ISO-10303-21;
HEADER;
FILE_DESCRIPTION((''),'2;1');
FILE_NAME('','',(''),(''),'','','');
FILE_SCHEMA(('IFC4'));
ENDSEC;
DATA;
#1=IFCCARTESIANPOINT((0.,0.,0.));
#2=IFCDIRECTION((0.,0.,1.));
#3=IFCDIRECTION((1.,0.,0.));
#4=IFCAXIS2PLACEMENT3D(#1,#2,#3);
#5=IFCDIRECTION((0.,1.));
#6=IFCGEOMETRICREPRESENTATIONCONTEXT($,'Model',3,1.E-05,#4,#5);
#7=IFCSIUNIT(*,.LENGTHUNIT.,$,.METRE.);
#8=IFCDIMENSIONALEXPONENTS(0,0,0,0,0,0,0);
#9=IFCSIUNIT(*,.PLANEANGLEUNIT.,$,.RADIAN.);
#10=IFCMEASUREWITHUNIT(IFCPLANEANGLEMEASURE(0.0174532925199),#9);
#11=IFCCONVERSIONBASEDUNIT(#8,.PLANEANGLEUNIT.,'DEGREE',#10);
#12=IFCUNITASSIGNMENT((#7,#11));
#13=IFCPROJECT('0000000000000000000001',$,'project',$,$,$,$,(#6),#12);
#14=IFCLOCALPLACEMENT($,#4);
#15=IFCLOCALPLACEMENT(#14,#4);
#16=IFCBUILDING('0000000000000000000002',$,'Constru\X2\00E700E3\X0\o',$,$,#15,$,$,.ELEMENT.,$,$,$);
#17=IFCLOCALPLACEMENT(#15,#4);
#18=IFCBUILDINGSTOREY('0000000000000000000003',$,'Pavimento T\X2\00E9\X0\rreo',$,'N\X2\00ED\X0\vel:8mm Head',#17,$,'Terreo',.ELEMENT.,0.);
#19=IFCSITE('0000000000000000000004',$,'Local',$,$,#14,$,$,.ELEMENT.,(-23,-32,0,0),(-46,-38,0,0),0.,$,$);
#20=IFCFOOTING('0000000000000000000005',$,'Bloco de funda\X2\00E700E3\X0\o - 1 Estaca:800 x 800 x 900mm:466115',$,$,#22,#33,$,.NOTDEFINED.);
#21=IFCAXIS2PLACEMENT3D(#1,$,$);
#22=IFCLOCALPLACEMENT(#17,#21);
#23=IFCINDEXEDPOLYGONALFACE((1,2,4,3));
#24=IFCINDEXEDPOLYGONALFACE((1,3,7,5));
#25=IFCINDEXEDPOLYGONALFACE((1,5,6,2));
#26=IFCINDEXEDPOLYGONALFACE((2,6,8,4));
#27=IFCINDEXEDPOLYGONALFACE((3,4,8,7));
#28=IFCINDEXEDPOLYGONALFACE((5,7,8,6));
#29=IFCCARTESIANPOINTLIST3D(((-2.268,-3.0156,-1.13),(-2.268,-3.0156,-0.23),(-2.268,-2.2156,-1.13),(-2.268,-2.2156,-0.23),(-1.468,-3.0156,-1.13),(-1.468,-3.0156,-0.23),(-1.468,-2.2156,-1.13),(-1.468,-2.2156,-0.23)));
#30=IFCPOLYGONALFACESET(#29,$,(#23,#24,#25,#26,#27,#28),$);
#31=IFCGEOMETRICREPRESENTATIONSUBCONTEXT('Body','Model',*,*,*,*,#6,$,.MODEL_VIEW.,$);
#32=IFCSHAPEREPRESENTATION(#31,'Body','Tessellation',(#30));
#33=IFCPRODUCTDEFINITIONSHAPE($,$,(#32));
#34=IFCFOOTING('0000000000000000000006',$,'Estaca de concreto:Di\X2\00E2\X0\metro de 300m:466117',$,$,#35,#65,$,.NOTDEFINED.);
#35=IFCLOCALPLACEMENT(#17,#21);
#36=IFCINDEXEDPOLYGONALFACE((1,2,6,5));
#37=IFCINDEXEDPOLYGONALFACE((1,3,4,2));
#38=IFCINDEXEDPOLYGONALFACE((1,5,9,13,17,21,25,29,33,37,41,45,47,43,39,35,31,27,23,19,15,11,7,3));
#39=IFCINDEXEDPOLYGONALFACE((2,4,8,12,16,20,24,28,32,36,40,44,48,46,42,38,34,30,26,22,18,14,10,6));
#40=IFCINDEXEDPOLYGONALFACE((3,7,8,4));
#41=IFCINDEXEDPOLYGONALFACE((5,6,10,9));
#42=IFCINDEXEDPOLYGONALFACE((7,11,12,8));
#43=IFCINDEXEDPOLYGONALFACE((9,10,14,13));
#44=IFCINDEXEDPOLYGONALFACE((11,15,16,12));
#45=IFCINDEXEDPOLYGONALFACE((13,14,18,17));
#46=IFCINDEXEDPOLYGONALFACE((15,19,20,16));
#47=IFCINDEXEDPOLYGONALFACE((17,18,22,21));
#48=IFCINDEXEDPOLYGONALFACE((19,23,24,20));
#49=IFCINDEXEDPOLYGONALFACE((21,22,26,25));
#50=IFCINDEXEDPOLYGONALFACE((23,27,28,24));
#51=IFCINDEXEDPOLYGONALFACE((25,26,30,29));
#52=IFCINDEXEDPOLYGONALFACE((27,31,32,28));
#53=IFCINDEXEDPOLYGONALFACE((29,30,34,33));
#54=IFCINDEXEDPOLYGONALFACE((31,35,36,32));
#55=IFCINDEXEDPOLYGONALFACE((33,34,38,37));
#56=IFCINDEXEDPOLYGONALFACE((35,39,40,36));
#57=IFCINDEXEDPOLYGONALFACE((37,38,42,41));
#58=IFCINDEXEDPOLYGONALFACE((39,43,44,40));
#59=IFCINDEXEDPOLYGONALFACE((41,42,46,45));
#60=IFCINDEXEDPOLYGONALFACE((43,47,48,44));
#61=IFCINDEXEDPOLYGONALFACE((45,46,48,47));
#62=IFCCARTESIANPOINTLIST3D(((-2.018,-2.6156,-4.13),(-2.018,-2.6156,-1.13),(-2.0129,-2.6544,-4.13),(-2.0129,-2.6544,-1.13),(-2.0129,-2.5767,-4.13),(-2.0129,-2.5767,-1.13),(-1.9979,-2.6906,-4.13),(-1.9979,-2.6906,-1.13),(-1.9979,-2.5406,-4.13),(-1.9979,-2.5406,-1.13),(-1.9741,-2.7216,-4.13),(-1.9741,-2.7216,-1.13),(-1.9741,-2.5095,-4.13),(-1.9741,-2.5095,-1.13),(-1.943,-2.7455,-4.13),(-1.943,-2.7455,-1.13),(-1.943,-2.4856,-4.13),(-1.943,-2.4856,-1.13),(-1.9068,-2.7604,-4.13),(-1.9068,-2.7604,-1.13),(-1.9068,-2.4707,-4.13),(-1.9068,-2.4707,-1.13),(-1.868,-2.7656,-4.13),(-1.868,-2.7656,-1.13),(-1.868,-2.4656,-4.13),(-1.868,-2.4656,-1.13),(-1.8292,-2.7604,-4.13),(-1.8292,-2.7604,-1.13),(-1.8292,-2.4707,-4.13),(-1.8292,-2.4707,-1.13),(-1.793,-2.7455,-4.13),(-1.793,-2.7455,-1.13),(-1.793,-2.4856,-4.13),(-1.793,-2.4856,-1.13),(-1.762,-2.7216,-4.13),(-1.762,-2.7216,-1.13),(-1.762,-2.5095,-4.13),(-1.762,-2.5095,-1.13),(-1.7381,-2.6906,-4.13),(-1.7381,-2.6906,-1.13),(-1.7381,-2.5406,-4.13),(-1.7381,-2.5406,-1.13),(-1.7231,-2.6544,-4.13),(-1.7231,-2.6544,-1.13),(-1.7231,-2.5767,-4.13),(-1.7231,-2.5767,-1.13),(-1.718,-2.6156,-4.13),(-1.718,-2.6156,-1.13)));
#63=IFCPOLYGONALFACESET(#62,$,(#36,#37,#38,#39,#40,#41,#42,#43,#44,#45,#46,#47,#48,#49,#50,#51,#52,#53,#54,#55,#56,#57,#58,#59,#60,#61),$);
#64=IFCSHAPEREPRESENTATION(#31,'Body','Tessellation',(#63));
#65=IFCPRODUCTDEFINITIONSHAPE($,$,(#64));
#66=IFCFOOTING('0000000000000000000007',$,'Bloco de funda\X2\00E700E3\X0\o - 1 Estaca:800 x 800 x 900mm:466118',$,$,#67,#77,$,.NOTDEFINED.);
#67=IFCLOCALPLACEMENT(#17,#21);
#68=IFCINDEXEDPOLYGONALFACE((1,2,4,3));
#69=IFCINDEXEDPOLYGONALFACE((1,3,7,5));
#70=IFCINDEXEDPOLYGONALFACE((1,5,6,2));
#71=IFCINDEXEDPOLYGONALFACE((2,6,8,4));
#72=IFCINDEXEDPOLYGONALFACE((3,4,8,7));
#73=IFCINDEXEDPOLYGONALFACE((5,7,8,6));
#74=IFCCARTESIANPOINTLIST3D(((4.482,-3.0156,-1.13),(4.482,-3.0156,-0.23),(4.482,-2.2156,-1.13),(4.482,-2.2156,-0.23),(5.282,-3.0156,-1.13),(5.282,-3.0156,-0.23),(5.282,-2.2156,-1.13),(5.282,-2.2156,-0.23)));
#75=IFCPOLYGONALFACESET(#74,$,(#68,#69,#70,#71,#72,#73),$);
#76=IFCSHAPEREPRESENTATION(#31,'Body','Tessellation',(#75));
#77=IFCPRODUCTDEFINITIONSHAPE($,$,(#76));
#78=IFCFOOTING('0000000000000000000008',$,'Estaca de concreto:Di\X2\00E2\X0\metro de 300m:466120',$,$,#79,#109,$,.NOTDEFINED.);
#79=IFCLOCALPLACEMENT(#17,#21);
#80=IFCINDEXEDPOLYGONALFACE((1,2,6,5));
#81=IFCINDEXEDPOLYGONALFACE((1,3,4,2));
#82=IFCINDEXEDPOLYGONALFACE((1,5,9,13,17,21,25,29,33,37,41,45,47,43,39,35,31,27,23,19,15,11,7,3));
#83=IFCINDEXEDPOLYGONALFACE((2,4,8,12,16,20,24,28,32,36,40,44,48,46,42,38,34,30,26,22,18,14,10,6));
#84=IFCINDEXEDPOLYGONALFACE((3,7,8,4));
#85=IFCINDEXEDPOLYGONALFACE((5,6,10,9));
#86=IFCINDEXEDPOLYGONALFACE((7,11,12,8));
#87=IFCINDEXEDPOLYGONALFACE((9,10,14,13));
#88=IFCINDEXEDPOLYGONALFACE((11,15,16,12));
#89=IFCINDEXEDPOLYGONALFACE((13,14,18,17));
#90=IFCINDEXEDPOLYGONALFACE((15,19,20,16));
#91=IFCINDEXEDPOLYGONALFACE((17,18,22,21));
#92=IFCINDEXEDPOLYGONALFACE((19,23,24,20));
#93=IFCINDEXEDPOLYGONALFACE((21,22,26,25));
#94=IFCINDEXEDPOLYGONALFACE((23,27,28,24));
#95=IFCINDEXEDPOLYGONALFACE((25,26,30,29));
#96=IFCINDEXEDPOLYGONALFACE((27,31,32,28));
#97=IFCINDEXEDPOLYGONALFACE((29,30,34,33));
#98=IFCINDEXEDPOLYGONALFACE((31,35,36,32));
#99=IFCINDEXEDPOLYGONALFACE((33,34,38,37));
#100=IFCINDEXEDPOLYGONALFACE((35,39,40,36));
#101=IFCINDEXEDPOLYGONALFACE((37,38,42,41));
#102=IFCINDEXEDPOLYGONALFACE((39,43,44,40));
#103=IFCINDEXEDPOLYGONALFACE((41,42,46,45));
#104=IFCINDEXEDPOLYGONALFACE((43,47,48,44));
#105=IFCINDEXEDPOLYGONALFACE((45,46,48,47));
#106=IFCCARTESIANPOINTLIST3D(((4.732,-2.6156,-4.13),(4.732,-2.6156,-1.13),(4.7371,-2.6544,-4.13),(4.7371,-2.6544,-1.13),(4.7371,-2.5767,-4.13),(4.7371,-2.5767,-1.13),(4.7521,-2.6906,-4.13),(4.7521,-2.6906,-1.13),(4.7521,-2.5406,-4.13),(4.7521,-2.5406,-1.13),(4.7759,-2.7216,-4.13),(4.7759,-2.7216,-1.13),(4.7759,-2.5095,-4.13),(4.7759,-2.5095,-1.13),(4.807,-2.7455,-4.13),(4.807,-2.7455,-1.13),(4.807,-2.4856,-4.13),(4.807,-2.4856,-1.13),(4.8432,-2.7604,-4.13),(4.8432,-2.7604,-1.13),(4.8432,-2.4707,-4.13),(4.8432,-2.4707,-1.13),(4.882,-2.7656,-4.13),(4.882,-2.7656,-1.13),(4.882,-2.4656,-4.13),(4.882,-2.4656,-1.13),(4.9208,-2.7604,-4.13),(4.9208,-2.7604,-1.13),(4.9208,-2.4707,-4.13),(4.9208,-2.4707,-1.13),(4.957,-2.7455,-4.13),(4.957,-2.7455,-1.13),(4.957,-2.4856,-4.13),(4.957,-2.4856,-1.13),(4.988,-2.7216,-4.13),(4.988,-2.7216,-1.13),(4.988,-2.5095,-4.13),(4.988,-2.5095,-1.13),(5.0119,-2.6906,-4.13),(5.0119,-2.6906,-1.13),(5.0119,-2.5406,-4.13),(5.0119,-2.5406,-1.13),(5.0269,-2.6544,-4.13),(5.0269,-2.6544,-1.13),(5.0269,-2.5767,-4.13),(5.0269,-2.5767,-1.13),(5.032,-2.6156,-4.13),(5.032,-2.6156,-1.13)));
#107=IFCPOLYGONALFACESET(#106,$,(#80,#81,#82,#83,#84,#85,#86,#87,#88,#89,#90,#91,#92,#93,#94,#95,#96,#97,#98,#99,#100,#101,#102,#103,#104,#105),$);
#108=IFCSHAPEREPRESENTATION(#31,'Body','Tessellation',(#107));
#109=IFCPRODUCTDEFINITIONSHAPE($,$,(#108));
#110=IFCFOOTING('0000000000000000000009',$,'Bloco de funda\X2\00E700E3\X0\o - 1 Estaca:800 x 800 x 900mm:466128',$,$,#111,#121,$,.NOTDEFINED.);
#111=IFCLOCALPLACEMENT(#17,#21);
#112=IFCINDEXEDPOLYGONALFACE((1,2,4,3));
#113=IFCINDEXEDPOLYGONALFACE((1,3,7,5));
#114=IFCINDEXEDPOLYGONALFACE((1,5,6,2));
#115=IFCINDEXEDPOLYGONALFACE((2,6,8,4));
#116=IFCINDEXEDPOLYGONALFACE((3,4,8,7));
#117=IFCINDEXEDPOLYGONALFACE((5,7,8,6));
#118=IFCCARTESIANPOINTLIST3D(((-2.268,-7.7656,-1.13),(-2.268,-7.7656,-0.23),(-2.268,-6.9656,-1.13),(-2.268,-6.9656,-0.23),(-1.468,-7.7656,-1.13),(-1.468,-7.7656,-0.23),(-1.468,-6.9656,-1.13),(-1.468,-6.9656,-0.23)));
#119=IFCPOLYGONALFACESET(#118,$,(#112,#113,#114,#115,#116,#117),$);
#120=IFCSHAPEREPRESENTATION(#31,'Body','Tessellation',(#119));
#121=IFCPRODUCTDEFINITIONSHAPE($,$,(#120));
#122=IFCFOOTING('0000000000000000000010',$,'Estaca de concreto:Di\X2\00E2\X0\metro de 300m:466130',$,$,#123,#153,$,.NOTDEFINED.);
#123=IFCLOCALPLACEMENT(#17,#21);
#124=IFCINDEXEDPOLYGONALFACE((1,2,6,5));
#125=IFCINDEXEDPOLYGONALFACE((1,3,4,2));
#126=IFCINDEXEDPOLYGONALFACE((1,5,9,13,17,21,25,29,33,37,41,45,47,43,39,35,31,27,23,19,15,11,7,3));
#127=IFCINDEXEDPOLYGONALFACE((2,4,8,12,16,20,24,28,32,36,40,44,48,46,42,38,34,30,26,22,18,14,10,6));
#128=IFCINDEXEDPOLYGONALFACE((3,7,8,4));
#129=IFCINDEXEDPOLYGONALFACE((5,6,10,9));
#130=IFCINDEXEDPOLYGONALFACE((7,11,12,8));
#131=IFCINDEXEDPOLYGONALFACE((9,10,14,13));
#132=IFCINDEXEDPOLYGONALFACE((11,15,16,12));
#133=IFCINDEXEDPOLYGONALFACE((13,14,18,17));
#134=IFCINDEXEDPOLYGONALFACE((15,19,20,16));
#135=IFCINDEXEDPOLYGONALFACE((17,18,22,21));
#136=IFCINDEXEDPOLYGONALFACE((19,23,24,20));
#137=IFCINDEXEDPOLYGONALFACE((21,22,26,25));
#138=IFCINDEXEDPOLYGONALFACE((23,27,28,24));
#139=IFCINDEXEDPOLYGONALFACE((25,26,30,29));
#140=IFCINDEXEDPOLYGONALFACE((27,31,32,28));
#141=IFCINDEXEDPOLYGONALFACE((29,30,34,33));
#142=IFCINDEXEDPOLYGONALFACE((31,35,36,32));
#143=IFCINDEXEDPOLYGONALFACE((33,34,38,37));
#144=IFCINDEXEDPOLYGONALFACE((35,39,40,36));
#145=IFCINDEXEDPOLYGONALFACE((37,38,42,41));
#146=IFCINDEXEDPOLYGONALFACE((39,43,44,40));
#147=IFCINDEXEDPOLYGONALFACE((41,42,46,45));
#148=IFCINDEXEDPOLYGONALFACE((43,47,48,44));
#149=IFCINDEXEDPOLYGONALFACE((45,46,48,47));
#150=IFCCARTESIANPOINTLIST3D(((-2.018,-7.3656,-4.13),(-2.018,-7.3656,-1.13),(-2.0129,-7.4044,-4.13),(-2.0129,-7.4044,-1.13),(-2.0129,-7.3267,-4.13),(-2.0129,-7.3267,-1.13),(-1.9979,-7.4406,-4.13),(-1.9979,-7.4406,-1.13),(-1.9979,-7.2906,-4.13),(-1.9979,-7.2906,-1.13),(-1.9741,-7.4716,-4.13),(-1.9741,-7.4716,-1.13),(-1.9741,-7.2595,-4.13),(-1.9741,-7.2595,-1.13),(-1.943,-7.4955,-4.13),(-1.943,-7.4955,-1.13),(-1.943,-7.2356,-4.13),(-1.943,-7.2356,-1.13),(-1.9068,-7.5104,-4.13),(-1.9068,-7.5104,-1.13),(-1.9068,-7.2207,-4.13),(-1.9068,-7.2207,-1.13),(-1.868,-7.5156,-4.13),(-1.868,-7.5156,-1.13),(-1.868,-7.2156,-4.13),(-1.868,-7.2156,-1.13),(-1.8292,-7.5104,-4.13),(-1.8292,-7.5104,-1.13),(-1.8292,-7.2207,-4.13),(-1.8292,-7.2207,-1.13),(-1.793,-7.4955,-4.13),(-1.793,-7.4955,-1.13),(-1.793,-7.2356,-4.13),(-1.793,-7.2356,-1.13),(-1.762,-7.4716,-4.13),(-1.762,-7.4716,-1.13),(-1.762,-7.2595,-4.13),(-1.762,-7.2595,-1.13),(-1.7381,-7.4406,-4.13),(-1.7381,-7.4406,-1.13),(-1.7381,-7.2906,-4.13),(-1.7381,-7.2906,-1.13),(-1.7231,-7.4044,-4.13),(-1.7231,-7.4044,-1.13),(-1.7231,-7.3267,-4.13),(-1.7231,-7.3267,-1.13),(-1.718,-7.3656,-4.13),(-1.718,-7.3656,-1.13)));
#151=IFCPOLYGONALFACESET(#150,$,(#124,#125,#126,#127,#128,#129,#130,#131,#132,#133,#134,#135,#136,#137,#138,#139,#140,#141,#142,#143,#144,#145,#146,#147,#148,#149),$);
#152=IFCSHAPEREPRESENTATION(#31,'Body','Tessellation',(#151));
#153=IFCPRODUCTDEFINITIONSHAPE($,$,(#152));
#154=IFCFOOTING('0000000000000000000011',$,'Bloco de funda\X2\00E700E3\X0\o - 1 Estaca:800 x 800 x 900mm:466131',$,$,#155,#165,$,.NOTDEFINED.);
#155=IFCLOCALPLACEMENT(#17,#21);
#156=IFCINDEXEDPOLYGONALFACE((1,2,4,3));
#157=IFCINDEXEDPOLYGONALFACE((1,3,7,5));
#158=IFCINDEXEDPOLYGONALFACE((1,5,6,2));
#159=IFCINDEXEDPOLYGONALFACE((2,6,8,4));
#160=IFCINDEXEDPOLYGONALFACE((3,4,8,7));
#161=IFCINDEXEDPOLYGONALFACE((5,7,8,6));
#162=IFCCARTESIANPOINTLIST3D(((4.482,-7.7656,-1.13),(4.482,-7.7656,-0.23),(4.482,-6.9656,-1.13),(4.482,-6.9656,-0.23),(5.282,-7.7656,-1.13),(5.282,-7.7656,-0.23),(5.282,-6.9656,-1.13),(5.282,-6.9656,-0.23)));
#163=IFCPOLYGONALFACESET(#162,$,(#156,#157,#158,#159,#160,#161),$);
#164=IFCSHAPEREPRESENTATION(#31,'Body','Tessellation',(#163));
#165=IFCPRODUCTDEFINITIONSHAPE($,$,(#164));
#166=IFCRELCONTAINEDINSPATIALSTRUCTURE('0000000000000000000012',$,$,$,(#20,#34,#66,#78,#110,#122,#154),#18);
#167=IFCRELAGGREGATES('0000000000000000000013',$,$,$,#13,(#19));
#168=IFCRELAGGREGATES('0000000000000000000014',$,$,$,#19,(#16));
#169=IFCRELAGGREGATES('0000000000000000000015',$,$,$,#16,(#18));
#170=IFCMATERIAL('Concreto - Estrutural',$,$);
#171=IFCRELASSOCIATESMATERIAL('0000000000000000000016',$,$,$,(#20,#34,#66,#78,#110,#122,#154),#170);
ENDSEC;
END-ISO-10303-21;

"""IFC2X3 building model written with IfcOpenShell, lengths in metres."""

from ifc_helpers import new_model, entity, si_unit, converted_unit, point, direction, frame, frame_2d, origin_with_axes, place, context, subcontext, project, spatial, polyline, circle_curve, parameter, trimmed, segment, composite_curve, outline, extrude, material, element, save


model = new_model("IFC2X3")

# Units and contexts
model_context = context("Model", 3, precision=1e-05, world=origin_with_axes(), true_north=direction((0.0, 1.0)))
body_context = subcontext(model_context, "Body", "Model", "MODEL_VIEW")
ifc_project = project(units=[si_unit("LENGTHUNIT", "METRE"), converted_unit("PLANEANGLEUNIT", "DEGREE", entity("IfcPlaneAngleMeasure", 0.0174532925199), si_unit("PLANEANGLEUNIT", "RADIAN"), dimensions=[0, 0, 0, 0, 0, 0, 0])], contexts=[model_context])

# Site, building, storey
site_placement = place(None, origin_with_axes())
site = spatial("IfcSite", under=ifc_project, at=site_placement, Name="Local", CompositionType="ELEMENT", RefLatitude=(-23, -32, 0, 0), RefLongitude=(-46, -38, 0, 0), RefElevation=0.0)
building_placement = place(site_placement, origin_with_axes())
building = spatial("IfcBuilding", under=site, at=building_placement, Name="Construção", CompositionType="ELEMENT")
storey_placement = place(building_placement, origin_with_axes())
storey = spatial("IfcBuildingStorey", under=building, at=storey_placement, Name="Pavimento Térreo", ObjectType="Nível:8mm Head", LongName="Terreo", CompositionType="ELEMENT", Elevation=0.0)

# Footings
ifc_material = material(Name="Concreto - Estrutural")
footing_1_placement = place(storey_placement, frame((-2.268, -2.2156, -0.23), z_axis=(0.0, 0.0, 1.0), x_axis=(1.0, 0.0, 0.0)))
element("IfcFooting", 1, at=footing_1_placement, inside=storey, material=ifc_material, Name="Bloco de fundação - 1 Estaca:800 x 800 x 900mm:466115", PredefinedType="NOTDEFINED", context=body_context, shape_type="SweptSolid", body=[
    extrude(outline(polyline([(0.0, 0.0), (0.0, -0.8), (0.8, -0.8), (0.8, 0.0), (0.0, 0.0)])), frame((0.0, 0.0, -0.9), z_axis=(0.0, 0.0, 1.0), x_axis=(1.0, 0.0, 0.0)), (0.0, 0.0, 1.0), 0.9),
])
footing_2_placement = place(storey_placement, frame((-1.718, -2.6156, -1.13), z_axis=(0.0, 0.0, 1.0), x_axis=(1.0, 0.0, 0.0)))
element("IfcFooting", 2, at=footing_2_placement, inside=storey, material=ifc_material, Name="Estaca de concreto:Diâmetro de 300m:466117", PredefinedType="NOTDEFINED", context=body_context, shape_type="SweptSolid", body=[
    extrude(outline(composite_curve([segment(trimmed(circle_curve(frame_2d((-0.15, 0.0), x_axis=(1.0, 0.0)), 0.15), [point((0.0, 0.0)), parameter(0.0)], [point((-0.15, 0.15)), parameter(90.0)], True, "CARTESIAN"), True, "CONTINUOUS"), segment(trimmed(circle_curve(frame_2d((-0.15, 0.0), x_axis=(0.0, 1.0)), 0.15), [point((-0.15, 0.15)), parameter(0.0)], [point((-0.3, 0.0)), parameter(90.0)], True, "CARTESIAN"), True, "CONTINUOUS"), segment(trimmed(circle_curve(frame_2d((-0.15, 0.0), x_axis=(-1.0, 0.0)), 0.15), [point((-0.3, 0.0)), parameter(0.0)], [point((-0.15, -0.15)), parameter(90.0)], True, "CARTESIAN"), True, "CONTINUOUS"), segment(trimmed(circle_curve(frame_2d((-0.15, 0.0), x_axis=(0.0, -1.0)), 0.15), [point((-0.15, -0.15)), parameter(0.0)], [point((0.0, 0.0)), parameter(90.0)], True, "CARTESIAN"), True, "CONTINUOUS")], self_intersect=False)), frame((0.0, 0.0, -3.0), z_axis=(0.0, 0.0, 1.0), x_axis=(1.0, 0.0, 0.0)), (0.0, 0.0, 1.0), 3.0),
])
footing_3_placement = place(storey_placement, frame((4.482, -2.2156, -0.23), z_axis=(0.0, 0.0, 1.0), x_axis=(1.0, 0.0, 0.0)))
element("IfcFooting", 3, at=footing_3_placement, inside=storey, material=ifc_material, Name="Bloco de fundação - 1 Estaca:800 x 800 x 900mm:466118", PredefinedType="NOTDEFINED", context=body_context, shape_type="SweptSolid", body=[
    extrude(outline(polyline([(0.0, 0.0), (0.0, -0.8), (0.8, -0.8), (0.8, 0.0), (0.0, 0.0)])), frame((0.0, 0.0, -0.9), z_axis=(0.0, 0.0, 1.0), x_axis=(1.0, 0.0, 0.0)), (0.0, 0.0, 1.0), 0.9),
])
footing_4_placement = place(storey_placement, frame((5.032, -2.6156, -1.13), z_axis=(0.0, 0.0, 1.0), x_axis=(1.0, 0.0, 0.0)))
element("IfcFooting", 4, at=footing_4_placement, inside=storey, material=ifc_material, Name="Estaca de concreto:Diâmetro de 300m:466120", PredefinedType="NOTDEFINED", context=body_context, shape_type="SweptSolid", body=[
    extrude(outline(composite_curve([segment(trimmed(circle_curve(frame_2d((-0.15, 0.0), x_axis=(1.0, 0.0)), 0.15), [point((0.0, 0.0)), parameter(0.0)], [point((-0.15, 0.15)), parameter(90.0)], True, "CARTESIAN"), True, "CONTINUOUS"), segment(trimmed(circle_curve(frame_2d((-0.15, 0.0), x_axis=(0.0, 1.0)), 0.15), [point((-0.15, 0.15)), parameter(0.0)], [point((-0.3, 0.0)), parameter(90.0)], True, "CARTESIAN"), True, "CONTINUOUS"), segment(trimmed(circle_curve(frame_2d((-0.15, 0.0), x_axis=(-1.0, 0.0)), 0.15), [point((-0.3, 0.0)), parameter(0.0)], [point((-0.15, -0.15)), parameter(90.0)], True, "CARTESIAN"), True, "CONTINUOUS"), segment(trimmed(circle_curve(frame_2d((-0.15, 0.0), x_axis=(0.0, -1.0)), 0.15), [point((-0.15, -0.15)), parameter(0.0)], [point((0.0, 0.0)), parameter(90.0)], True, "CARTESIAN"), True, "CONTINUOUS")], self_intersect=False)), frame((0.0, 0.0, -3.0), z_axis=(0.0, 0.0, 1.0), x_axis=(1.0, 0.0, 0.0)), (0.0, 0.0, 1.0), 3.0),
])
footing_5_placement = place(storey_placement, frame((-2.268, -6.9656, -0.23), z_axis=(0.0, 0.0, 1.0), x_axis=(1.0, 0.0, 0.0)))
element("IfcFooting", 5, at=footing_5_placement, inside=storey, material=ifc_material, Name="Bloco de fundação - 1 Estaca:800 x 800 x 900mm:466128", PredefinedType="NOTDEFINED", context=body_context, shape_type="SweptSolid", body=[
    extrude(outline(polyline([(0.0, 0.0), (0.0, -0.8), (0.8, -0.8), (0.8, 0.0), (0.0, 0.0)])), frame((0.0, 0.0, -0.9), z_axis=(0.0, 0.0, 1.0), x_axis=(1.0, 0.0, 0.0)), (0.0, 0.0, 1.0), 0.9),
])
footing_6_placement = place(storey_placement, frame((-1.718, -7.3656, -1.13), z_axis=(0.0, 0.0, 1.0), x_axis=(1.0, 0.0, 0.0)))
element("IfcFooting", 6, at=footing_6_placement, inside=storey, material=ifc_material, Name="Estaca de concreto:Diâmetro de 300m:466130", PredefinedType="NOTDEFINED", context=body_context, shape_type="SweptSolid", body=[
    extrude(outline(composite_curve([segment(trimmed(circle_curve(frame_2d((-0.15, 0.0), x_axis=(1.0, 0.0)), 0.15), [point((0.0, 0.0)), parameter(0.0)], [point((-0.15, 0.15)), parameter(90.0)], True, "CARTESIAN"), True, "CONTINUOUS"), segment(trimmed(circle_curve(frame_2d((-0.15, 0.0), x_axis=(0.0, 1.0)), 0.15), [point((-0.15, 0.15)), parameter(0.0)], [point((-0.3, 0.0)), parameter(90.0)], True, "CARTESIAN"), True, "CONTINUOUS"), segment(trimmed(circle_curve(frame_2d((-0.15, 0.0), x_axis=(-1.0, 0.0)), 0.15), [point((-0.3, 0.0)), parameter(0.0)], [point((-0.15, -0.15)), parameter(90.0)], True, "CARTESIAN"), True, "CONTINUOUS"), segment(trimmed(circle_curve(frame_2d((-0.15, 0.0), x_axis=(0.0, -1.0)), 0.15), [point((-0.15, -0.15)), parameter(0.0)], [point((0.0, 0.0)), parameter(90.0)], True, "CARTESIAN"), True, "CONTINUOUS")], self_intersect=False)), frame((0.0, 0.0, -3.0), z_axis=(0.0, 0.0, 1.0), x_axis=(1.0, 0.0, 0.0)), (0.0, 0.0, 1.0), 3.0),
])
footing_7_placement = place(storey_placement, frame((4.482, -6.9656, -0.23), z_axis=(0.0, 0.0, 1.0), x_axis=(1.0, 0.0, 0.0)))
element("IfcFooting", 7, at=footing_7_placement, inside=storey, material=ifc_material, Name="Bloco de fundação - 1 Estaca:800 x 800 x 900mm:466131", PredefinedType="NOTDEFINED", context=body_context, shape_type="SweptSolid", body=[
    extrude(outline(polyline([(0.0, 0.0), (0.0, -0.8), (0.8, -0.8), (0.8, 0.0), (0.0, 0.0)])), frame((0.0, 0.0, -0.9), z_axis=(0.0, 0.0, 1.0), x_axis=(1.0, 0.0, 0.0)), (0.0, 0.0, 1.0), 0.9),
])

save(model, "model.ifc")
